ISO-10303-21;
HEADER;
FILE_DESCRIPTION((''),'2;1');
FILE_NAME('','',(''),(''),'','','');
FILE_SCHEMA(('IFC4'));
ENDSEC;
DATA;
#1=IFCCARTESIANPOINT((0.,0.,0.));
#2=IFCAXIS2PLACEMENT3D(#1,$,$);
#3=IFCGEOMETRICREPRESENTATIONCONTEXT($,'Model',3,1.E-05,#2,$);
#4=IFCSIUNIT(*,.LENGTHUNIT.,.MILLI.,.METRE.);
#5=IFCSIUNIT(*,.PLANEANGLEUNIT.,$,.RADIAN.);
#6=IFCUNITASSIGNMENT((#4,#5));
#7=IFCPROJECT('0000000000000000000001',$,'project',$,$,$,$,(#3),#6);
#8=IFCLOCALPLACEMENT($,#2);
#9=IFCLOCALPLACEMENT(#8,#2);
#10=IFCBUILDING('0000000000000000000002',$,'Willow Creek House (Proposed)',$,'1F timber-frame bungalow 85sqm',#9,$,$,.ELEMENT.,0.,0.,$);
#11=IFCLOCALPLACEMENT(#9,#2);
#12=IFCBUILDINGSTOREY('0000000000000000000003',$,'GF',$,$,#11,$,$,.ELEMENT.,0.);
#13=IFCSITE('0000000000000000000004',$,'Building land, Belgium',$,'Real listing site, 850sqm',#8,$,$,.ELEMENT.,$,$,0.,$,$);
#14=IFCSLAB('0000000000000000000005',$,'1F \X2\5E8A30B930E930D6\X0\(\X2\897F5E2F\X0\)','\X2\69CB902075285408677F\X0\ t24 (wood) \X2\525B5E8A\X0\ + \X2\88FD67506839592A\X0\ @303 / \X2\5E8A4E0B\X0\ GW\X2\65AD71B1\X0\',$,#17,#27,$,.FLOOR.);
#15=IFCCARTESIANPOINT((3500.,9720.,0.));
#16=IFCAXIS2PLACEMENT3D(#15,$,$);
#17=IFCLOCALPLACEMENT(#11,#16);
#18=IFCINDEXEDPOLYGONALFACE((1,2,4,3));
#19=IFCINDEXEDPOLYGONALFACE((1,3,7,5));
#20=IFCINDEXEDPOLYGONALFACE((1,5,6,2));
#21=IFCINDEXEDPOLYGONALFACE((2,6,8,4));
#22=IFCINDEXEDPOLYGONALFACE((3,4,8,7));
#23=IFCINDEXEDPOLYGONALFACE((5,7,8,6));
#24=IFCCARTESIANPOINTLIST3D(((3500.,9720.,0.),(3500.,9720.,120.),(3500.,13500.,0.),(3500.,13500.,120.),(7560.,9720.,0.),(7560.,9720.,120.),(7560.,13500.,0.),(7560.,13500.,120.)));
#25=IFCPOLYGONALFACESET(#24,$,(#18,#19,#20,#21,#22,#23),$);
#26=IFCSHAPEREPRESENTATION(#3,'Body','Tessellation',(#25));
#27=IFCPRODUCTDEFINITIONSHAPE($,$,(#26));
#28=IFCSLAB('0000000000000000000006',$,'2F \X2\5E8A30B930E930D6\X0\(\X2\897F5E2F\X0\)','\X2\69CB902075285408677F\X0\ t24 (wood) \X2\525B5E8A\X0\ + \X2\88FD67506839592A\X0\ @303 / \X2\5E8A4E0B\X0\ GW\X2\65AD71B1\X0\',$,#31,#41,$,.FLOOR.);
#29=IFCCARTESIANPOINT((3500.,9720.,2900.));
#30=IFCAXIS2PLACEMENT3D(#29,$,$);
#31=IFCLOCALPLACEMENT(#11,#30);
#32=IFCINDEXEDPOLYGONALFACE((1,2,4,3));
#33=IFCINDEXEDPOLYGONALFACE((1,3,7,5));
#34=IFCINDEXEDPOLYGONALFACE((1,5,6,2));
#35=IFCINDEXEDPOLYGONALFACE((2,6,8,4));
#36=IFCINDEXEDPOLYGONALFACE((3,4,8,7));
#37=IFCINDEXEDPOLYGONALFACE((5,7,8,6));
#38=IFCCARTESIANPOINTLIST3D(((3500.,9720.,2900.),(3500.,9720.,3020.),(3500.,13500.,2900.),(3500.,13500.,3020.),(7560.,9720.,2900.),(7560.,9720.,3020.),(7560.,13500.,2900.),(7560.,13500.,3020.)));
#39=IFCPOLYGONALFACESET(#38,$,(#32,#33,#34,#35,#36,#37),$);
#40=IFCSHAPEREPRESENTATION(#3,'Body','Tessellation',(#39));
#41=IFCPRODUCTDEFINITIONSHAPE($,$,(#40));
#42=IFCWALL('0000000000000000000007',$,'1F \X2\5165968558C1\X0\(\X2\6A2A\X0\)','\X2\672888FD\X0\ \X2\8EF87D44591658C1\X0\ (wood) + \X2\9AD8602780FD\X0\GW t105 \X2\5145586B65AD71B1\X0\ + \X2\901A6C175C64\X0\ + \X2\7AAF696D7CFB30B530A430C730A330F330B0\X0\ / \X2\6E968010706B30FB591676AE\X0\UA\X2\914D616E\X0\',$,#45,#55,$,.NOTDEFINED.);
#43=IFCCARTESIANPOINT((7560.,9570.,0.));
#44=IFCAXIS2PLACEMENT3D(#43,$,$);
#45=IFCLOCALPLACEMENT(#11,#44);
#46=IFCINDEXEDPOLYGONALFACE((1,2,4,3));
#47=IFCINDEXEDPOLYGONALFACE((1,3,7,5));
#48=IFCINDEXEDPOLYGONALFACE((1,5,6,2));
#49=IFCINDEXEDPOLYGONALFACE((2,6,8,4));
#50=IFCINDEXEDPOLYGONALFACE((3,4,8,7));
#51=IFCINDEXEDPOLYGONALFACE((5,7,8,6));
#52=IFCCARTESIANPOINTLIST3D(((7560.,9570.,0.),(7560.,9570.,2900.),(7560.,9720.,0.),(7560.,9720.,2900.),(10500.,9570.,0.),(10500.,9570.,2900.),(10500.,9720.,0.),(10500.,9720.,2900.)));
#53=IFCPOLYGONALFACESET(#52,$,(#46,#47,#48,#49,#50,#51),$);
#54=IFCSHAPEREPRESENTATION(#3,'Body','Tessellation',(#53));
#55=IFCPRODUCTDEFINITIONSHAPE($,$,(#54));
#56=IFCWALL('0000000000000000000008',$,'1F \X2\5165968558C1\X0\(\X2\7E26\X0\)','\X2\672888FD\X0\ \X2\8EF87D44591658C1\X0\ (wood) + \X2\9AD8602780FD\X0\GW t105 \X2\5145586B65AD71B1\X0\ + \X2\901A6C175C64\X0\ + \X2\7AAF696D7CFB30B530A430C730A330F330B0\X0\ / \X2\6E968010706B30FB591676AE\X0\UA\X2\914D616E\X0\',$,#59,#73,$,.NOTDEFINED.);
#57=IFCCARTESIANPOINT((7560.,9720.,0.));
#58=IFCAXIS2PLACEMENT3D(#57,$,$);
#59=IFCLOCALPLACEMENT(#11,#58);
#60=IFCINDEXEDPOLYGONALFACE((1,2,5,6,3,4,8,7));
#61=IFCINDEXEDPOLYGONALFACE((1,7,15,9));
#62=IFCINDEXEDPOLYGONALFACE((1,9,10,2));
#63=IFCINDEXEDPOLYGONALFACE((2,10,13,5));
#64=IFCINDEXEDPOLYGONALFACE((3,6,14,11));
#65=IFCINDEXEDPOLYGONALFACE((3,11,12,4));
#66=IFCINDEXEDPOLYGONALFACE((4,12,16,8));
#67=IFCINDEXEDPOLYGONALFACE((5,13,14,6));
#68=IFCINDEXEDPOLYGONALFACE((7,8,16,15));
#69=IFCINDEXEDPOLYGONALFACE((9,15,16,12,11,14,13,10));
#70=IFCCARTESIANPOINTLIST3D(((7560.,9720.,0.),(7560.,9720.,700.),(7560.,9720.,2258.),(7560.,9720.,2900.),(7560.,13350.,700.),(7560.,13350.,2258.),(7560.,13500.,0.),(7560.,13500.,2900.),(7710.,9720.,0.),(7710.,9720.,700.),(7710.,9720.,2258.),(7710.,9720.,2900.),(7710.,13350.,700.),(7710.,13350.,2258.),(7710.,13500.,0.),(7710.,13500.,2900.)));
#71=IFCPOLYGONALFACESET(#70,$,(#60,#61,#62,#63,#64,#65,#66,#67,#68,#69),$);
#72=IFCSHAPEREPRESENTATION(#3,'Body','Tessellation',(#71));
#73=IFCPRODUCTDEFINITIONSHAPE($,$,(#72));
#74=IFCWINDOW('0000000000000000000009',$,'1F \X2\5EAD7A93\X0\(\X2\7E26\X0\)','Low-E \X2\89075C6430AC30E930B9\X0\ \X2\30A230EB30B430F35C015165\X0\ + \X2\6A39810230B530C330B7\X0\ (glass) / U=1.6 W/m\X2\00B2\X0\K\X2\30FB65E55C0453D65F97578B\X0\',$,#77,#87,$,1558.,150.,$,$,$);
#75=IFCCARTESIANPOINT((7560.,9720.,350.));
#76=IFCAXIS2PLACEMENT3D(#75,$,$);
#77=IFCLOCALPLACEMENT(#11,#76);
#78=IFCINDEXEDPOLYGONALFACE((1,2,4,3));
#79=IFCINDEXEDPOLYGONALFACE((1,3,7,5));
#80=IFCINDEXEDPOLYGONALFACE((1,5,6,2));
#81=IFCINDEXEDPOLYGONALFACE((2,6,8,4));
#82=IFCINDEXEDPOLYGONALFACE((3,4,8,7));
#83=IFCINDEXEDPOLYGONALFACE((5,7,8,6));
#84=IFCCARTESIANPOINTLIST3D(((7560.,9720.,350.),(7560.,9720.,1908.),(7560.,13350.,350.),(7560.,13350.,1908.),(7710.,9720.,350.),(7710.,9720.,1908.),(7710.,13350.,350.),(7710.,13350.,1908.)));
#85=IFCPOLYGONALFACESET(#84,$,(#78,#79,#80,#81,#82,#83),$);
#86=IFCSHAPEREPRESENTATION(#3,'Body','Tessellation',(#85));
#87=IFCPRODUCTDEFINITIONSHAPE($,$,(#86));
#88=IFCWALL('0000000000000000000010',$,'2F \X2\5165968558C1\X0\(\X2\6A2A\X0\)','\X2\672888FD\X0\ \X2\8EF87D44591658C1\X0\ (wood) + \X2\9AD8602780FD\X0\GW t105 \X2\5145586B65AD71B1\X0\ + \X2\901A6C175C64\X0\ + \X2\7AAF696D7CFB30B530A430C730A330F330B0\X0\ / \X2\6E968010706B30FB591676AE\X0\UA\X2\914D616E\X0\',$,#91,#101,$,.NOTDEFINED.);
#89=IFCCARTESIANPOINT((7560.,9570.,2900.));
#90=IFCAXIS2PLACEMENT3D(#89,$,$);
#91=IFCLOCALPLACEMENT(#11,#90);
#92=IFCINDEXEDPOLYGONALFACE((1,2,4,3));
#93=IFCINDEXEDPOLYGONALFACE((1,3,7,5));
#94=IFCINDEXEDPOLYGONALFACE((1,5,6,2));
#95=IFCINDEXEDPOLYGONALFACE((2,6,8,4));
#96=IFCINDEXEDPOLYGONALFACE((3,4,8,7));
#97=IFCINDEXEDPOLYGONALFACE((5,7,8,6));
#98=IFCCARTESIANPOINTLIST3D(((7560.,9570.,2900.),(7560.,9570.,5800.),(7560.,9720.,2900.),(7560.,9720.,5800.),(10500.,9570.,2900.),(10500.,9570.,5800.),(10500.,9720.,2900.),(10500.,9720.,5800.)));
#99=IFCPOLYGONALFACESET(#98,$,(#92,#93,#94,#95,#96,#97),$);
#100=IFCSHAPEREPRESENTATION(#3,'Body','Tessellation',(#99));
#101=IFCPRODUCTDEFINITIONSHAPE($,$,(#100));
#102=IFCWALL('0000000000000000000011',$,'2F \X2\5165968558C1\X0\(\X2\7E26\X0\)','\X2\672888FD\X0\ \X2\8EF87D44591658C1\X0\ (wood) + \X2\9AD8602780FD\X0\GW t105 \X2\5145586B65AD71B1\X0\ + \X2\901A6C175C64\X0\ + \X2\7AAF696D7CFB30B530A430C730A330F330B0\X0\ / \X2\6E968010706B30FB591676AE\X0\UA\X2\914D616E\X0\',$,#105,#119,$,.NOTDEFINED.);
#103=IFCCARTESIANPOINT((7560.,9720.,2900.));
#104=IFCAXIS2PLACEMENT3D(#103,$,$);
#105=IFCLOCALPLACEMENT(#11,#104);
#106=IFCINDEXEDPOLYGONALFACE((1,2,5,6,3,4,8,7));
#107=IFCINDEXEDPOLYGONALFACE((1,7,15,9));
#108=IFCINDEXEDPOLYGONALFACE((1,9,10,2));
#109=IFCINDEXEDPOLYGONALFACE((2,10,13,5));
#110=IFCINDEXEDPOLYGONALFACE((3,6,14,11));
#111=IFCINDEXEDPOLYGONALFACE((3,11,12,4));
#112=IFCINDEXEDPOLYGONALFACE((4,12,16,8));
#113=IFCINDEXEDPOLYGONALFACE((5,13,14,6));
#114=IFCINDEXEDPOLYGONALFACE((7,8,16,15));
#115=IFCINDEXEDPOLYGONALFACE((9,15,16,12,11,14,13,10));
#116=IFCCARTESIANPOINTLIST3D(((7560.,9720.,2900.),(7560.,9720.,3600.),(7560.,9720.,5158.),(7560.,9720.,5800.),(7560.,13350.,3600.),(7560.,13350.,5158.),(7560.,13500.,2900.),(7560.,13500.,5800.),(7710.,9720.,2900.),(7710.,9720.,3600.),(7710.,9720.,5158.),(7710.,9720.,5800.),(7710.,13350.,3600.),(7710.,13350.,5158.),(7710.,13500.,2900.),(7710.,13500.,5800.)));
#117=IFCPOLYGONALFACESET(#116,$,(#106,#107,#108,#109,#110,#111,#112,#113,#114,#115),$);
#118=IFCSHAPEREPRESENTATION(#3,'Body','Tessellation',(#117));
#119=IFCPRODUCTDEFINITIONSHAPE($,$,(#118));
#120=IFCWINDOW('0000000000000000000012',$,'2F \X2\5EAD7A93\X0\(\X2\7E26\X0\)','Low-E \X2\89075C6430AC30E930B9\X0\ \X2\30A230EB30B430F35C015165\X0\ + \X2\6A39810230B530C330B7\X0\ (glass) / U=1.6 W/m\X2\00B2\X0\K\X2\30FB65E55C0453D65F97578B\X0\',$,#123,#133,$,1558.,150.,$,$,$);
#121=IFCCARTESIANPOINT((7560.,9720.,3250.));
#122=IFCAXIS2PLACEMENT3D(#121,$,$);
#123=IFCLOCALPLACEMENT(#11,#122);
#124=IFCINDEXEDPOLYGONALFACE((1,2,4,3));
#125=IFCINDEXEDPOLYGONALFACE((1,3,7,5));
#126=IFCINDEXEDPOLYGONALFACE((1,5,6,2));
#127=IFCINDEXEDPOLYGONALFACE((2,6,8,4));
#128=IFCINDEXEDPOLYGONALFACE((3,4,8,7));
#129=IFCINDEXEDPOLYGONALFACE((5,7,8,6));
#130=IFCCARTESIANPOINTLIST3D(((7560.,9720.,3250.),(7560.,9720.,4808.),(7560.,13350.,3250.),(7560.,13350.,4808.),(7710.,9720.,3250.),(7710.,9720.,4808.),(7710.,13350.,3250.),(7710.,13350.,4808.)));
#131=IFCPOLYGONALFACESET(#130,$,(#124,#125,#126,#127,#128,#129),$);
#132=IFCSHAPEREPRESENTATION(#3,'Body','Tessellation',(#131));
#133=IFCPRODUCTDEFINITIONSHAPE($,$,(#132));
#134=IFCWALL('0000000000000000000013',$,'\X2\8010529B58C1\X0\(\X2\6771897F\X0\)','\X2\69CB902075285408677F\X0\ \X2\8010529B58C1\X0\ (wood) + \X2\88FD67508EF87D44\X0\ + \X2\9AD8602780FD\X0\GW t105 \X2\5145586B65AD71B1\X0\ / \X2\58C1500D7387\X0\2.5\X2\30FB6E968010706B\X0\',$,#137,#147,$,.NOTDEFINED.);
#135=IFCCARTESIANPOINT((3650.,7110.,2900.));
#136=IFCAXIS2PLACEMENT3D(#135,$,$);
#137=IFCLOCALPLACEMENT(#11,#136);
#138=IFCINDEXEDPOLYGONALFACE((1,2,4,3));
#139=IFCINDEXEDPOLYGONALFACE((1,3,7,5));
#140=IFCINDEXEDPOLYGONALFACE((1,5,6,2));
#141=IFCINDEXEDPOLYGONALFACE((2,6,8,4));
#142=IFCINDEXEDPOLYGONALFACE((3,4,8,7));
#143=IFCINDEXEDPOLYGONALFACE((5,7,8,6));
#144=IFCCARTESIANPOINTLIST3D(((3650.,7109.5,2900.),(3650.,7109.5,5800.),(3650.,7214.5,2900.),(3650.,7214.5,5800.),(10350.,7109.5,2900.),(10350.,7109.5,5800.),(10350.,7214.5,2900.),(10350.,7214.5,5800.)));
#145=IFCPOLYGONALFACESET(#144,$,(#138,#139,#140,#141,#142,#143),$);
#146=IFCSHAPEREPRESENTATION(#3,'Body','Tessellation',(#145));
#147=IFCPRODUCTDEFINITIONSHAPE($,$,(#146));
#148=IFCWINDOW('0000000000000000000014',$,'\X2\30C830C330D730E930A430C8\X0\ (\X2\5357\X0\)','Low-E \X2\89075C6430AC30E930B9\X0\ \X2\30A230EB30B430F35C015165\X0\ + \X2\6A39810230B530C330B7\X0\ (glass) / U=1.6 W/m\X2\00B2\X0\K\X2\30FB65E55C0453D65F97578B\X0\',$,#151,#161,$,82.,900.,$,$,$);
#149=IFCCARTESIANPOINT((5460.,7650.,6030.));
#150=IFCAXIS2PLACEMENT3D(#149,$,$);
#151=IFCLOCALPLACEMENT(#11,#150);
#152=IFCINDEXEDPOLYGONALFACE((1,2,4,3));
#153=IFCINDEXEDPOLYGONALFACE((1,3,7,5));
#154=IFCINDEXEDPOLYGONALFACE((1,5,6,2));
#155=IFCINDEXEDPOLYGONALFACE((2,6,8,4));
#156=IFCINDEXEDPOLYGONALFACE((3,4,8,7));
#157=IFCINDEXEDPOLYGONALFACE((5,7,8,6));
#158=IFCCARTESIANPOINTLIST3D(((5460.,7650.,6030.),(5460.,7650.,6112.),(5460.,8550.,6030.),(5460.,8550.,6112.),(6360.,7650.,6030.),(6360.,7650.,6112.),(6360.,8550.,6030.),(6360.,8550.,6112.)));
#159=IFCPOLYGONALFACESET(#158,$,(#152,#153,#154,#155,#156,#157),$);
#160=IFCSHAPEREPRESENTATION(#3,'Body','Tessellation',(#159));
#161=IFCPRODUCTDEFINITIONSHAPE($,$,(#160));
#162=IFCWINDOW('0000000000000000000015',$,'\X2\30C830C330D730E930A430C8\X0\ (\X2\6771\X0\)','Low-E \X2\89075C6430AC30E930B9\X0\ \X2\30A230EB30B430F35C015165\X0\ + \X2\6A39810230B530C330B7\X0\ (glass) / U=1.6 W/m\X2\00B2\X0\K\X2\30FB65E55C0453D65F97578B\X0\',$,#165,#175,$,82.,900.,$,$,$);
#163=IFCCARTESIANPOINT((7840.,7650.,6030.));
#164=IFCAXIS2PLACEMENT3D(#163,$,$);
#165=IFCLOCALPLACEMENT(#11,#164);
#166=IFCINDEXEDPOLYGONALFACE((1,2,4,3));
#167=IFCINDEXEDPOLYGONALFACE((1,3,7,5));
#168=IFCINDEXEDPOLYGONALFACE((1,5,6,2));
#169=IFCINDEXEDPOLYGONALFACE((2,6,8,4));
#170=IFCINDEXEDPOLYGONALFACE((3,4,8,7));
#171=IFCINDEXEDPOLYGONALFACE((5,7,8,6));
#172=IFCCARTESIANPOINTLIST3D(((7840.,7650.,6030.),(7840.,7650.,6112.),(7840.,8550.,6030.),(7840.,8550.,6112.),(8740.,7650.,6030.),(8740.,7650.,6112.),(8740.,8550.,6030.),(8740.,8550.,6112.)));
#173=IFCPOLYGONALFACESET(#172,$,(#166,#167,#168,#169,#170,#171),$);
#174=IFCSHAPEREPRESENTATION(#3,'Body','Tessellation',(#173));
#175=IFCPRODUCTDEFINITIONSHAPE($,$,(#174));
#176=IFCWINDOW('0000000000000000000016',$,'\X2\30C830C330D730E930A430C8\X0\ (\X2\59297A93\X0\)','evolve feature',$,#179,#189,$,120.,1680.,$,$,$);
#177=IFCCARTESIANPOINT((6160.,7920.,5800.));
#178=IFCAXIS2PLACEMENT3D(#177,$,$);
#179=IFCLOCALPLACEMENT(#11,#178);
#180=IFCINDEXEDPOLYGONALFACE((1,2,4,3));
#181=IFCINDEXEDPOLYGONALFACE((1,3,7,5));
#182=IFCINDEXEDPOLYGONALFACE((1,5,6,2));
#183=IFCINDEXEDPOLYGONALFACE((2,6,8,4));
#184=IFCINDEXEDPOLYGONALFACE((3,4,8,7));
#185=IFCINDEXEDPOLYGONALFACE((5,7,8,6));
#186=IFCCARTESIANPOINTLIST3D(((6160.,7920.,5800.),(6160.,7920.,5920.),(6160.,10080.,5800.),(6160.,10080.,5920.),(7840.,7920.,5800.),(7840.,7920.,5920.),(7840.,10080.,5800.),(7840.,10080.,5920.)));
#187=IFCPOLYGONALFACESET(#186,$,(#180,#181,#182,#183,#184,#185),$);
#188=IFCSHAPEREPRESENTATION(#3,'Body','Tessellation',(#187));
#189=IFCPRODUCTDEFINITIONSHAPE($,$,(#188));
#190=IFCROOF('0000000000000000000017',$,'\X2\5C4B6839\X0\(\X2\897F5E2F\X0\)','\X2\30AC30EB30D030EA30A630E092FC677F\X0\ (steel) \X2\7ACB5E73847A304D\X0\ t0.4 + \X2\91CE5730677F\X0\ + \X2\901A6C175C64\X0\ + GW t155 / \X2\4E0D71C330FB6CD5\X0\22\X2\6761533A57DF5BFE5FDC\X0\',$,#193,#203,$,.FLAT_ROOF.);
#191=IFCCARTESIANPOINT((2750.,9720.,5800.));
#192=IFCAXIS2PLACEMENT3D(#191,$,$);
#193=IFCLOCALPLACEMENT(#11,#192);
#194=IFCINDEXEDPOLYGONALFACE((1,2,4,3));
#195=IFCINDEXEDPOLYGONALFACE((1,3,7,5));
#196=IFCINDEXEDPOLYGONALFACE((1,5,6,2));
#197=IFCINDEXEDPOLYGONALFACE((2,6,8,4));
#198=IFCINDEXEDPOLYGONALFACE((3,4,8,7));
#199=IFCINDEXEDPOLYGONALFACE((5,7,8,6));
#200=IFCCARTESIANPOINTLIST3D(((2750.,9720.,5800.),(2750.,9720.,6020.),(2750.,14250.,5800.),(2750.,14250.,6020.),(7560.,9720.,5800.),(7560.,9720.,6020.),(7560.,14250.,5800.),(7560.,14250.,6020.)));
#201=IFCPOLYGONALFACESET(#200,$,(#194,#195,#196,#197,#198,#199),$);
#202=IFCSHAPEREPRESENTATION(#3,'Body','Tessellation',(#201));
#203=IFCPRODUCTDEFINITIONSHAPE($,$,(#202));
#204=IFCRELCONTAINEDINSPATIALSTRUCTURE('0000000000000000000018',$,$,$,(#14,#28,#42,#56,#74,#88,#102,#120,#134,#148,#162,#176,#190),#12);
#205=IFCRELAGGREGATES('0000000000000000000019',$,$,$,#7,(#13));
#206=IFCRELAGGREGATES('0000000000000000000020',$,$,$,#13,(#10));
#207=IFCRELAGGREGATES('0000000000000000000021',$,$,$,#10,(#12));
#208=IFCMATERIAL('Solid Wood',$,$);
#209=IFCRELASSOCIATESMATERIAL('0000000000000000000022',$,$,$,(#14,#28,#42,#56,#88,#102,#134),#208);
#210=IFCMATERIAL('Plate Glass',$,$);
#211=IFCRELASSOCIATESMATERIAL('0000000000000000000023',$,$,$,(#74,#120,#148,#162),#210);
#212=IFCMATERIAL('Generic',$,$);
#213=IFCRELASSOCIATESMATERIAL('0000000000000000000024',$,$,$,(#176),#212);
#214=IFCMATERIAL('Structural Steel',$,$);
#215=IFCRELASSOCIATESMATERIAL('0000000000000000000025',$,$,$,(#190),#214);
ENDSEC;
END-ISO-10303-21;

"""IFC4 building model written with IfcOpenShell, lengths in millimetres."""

from ifc_helpers import new_model, si_unit, frame, frame_2d, origin, place, context, project, spatial, rectangle, extrude, material, element, fill, save


model = new_model("IFC4")

# Units and contexts
model_context = context("Model", 3, precision=1e-05, world=origin())
ifc_project = project(units=[si_unit("LENGTHUNIT", "METRE", prefix="MILLI"), si_unit("PLANEANGLEUNIT", "RADIAN")], contexts=[model_context])

# Site, building, storey
site_placement = place(None, origin())
site = spatial("IfcSite", under=ifc_project, at=site_placement, Name="Building land, Belgium", ObjectType="Real listing site, 850sqm", CompositionType="ELEMENT", RefElevation=0.0)
building_placement = place(site_placement, origin())
building = spatial("IfcBuilding", under=site, at=building_placement, Name="Willow Creek House (Proposed)", ObjectType="1F timber-frame bungalow 85sqm", CompositionType="ELEMENT", ElevationOfRefHeight=0.0, ElevationOfTerrain=0.0)
storey_placement = place(building_placement, origin())
storey = spatial("IfcBuildingStorey", under=building, at=storey_placement, Name="GF", CompositionType="ELEMENT", Elevation=0.0)

# Slabs
ifc_material_1 = material(Name="Solid Wood")
slab_1_placement = place(storey_placement, frame((3500.0, 9720.0, 0.0)))
element("IfcSlab", 1, at=slab_1_placement, inside=storey, material=ifc_material_1, Name="1F 床スラブ(西帯)", Description="構造用合板 t24 (wood) 剛床 + 製材根太 @303 / 床下 GW断熱", PredefinedType="FLOOR", context=model_context, shape_type="SweptSolid", body=[
    extrude(rectangle(XDim=4060.0, YDim=3780.0, at=frame_2d((2030.0, 1890.0))), frame((3500.0, 9720.0, 0.0)), (0.0, 0.0, 1.0), 120.0),
])
slab_2_placement = place(storey_placement, frame((3500.0, 9720.0, 2900.0)))
element("IfcSlab", 2, at=slab_2_placement, inside=storey, material=ifc_material_1, Name="2F 床スラブ(西帯)", Description="構造用合板 t24 (wood) 剛床 + 製材根太 @303 / 床下 GW断熱", PredefinedType="FLOOR", context=model_context, shape_type="SweptSolid", body=[
    extrude(rectangle(XDim=4060.0, YDim=3780.0, at=frame_2d((2030.0, 1890.0))), frame((3500.0, 9720.0, 2900.0)), (0.0, 0.0, 1.0), 120.0),
])

# Wall
wall_1_placement = place(storey_placement, frame((7560.0, 9570.0, 0.0)))
element("IfcWall", 3, at=wall_1_placement, inside=storey, material=ifc_material_1, Name="1F 入隅壁(横)", Description="木製 軸組外壁 (wood) + 高性能GW t105 充填断熱 + 通気層 + 窯業系サイディング / 準耐火・外皮UA配慮", PredefinedType="NOTDEFINED", context=model_context, shape_type="SweptSolid", body=[
    extrude(rectangle(XDim=2940.0, YDim=150.0, at=frame_2d((1470.0, 75.0))), frame((7560.0, 9570.0, 0.0)), (0.0, 0.0, 1.0), 2900.0),
])

# Wall, opening, window
wall_2_placement = place(storey_placement, frame((7560.0, 9720.0, 0.0)))
wall_2 = element("IfcWall", 4, at=wall_2_placement, inside=storey, material=ifc_material_1, Name="1F 入隅壁(縦)", Description="木製 軸組外壁 (wood) + 高性能GW t105 充填断熱 + 通気層 + 窯業系サイディング / 準耐火・外皮UA配慮", PredefinedType="NOTDEFINED", context=model_context, shape_type="SweptSolid", body=[
    extrude(rectangle(XDim=150.0, YDim=3780.0, at=frame_2d((75.0, 1890.0))), frame((7560.0, 9720.0, 0.0)), (0.0, 0.0, 1.0), 2900.0),
])
opening_1_placement = place(storey_placement, frame((7560.0, 9720.0, 350.0)))
opening_1 = element("IfcOpeningElement", 5, at=opening_1_placement, cuts=wall_2, PredefinedType="NOTDEFINED", context=model_context, shape_type="SweptSolid", body=[
    extrude(rectangle(XDim=150.0, YDim=3630.0, at=frame_2d((75.0, 1815.0))), frame((7560.0, 9720.0, 350.0)), (0.0, 0.0, 1.0), 1558.0),
])
ifc_material_2 = material(Name="Plate Glass")
window_1_placement = place(storey_placement, frame((7560.0, 9720.0, 350.0)))
window_1 = element("IfcWindow", 6, at=window_1_placement, inside=storey, material=ifc_material_2, Name="1F 庭窓(縦)", Description="Low-E 複層ガラス アルゴン封入 + 樹脂サッシ (glass) / U=1.6 W/m²K・日射取得型", OverallHeight=1558.0, OverallWidth=150.0, context=model_context, shape_type="SweptSolid", body=[
    extrude(rectangle(XDim=150.0, YDim=3630.0, at=frame_2d((75.0, 1815.0))), frame((7560.0, 9720.0, 350.0)), (0.0, 0.0, 1.0), 1558.0),
])
fill(opening_1, window_1)

# Wall
wall_3_placement = place(storey_placement, frame((7560.0, 9570.0, 2900.0)))
element("IfcWall", 7, at=wall_3_placement, inside=storey, material=ifc_material_1, Name="2F 入隅壁(横)", Description="木製 軸組外壁 (wood) + 高性能GW t105 充填断熱 + 通気層 + 窯業系サイディング / 準耐火・外皮UA配慮", PredefinedType="NOTDEFINED", context=model_context, shape_type="SweptSolid", body=[
    extrude(rectangle(XDim=2940.0, YDim=150.0, at=frame_2d((1470.0, 75.0))), frame((7560.0, 9570.0, 2900.0)), (0.0, 0.0, 1.0), 2900.0),
])

# Wall, opening, window
wall_4_placement = place(storey_placement, frame((7560.0, 9720.0, 2900.0)))
wall_4 = element("IfcWall", 8, at=wall_4_placement, inside=storey, material=ifc_material_1, Name="2F 入隅壁(縦)", Description="木製 軸組外壁 (wood) + 高性能GW t105 充填断熱 + 通気層 + 窯業系サイディング / 準耐火・外皮UA配慮", PredefinedType="NOTDEFINED", context=model_context, shape_type="SweptSolid", body=[
    extrude(rectangle(XDim=150.0, YDim=3780.0, at=frame_2d((75.0, 1890.0))), frame((7560.0, 9720.0, 2900.0)), (0.0, 0.0, 1.0), 2900.0),
])
opening_2_placement = place(storey_placement, frame((7560.0, 9720.0, 3250.0)))
opening_2 = element("IfcOpeningElement", 9, at=opening_2_placement, cuts=wall_4, PredefinedType="NOTDEFINED", context=model_context, shape_type="SweptSolid", body=[
    extrude(rectangle(XDim=150.0, YDim=3630.0, at=frame_2d((75.0, 1815.0))), frame((7560.0, 9720.0, 3250.0)), (0.0, 0.0, 1.0), 1558.0),
])
window_2_placement = place(storey_placement, frame((7560.0, 9720.0, 3250.0)))
window_2 = element("IfcWindow", 10, at=window_2_placement, inside=storey, material=ifc_material_2, Name="2F 庭窓(縦)", Description="Low-E 複層ガラス アルゴン封入 + 樹脂サッシ (glass) / U=1.6 W/m²K・日射取得型", OverallHeight=1558.0, OverallWidth=150.0, context=model_context, shape_type="SweptSolid", body=[
    extrude(rectangle(XDim=150.0, YDim=3630.0, at=frame_2d((75.0, 1815.0))), frame((7560.0, 9720.0, 3250.0)), (0.0, 0.0, 1.0), 1558.0),
])
fill(opening_2, window_2)

# Wall
wall_5_placement = place(storey_placement, frame((3650.0, 7110.0, 2900.0)))
element("IfcWall", 11, at=wall_5_placement, inside=storey, material=ifc_material_1, Name="耐力壁(東西)", Description="構造用合板 耐力壁 (wood) + 製材軸組 + 高性能GW t105 充填断熱 / 壁倍率2.5・準耐火", PredefinedType="NOTDEFINED", context=model_context, shape_type="SweptSolid", body=[
    extrude(rectangle(XDim=6700.0, YDim=105.0, at=frame_2d((3350.0, 52.0))), frame((3650.0, 7110.0, 2900.0)), (0.0, 0.0, 1.0), 2900.0),
])

# Windows
window_3_placement = place(storey_placement, frame((5460.0, 7650.0, 6030.0)))
element("IfcWindow", 12, at=window_3_placement, inside=storey, material=ifc_material_2, Name="トップライト (南)", Description="Low-E 複層ガラス アルゴン封入 + 樹脂サッシ (glass) / U=1.6 W/m²K・日射取得型", OverallHeight=82.0, OverallWidth=900.0, context=model_context, shape_type="SweptSolid", body=[
    extrude(rectangle(XDim=900.0, YDim=900.0, at=frame_2d((450.0, 450.0))), frame((5460.0, 7650.0, 6030.0)), (0.0, 0.0, 1.0), 82.0),
])
window_4_placement = place(storey_placement, frame((7840.0, 7650.0, 6030.0)))
element("IfcWindow", 13, at=window_4_placement, inside=storey, material=ifc_material_2, Name="トップライト (東)", Description="Low-E 複層ガラス アルゴン封入 + 樹脂サッシ (glass) / U=1.6 W/m²K・日射取得型", OverallHeight=82.0, OverallWidth=900.0, context=model_context, shape_type="SweptSolid", body=[
    extrude(rectangle(XDim=900.0, YDim=900.0, at=frame_2d((450.0, 450.0))), frame((7840.0, 7650.0, 6030.0)), (0.0, 0.0, 1.0), 82.0),
])
ifc_material_3 = material(Name="Generic")
window_5_placement = place(storey_placement, frame((6160.0, 7920.0, 5800.0)))
element("IfcWindow", 14, at=window_5_placement, inside=storey, material=ifc_material_3, Name="トップライト (天窓)", Description="evolve feature", OverallHeight=120.0, OverallWidth=1680.0, context=model_context, shape_type="SweptSolid", body=[
    extrude(rectangle(XDim=1680.0, YDim=2160.0, at=frame_2d((840.0, 1080.0))), frame((6160.0, 7920.0, 5800.0)), (0.0, 0.0, 1.0), 120.0),
])

# Roof
ifc_material_4 = material(Name="Structural Steel")
for number, where, name in (
    (15, (2750.0, 9720.0, 5800.0), "屋根(西帯)"),
):
    element("IfcRoof", number, at=place(storey_placement, frame(where)), inside=storey, material=ifc_material_4, Name=name, Description="ガルバリウム鋼板 (steel) 立平葺き t0.4 + 野地板 + 通気層 + GW t155 / 不燃・法22条区域対応", PredefinedType="FLAT_ROOF", context=model_context, shape_type="SweptSolid", body=[
        extrude(rectangle(XDim=4810.0, YDim=4530.0, at=frame_2d((2405.0, 2265.0))), frame((2750.0, 9720.0, 5800.0)), (0.0, 0.0, 1.0), 220.0),
    ])

save(model, "model.ifc")
